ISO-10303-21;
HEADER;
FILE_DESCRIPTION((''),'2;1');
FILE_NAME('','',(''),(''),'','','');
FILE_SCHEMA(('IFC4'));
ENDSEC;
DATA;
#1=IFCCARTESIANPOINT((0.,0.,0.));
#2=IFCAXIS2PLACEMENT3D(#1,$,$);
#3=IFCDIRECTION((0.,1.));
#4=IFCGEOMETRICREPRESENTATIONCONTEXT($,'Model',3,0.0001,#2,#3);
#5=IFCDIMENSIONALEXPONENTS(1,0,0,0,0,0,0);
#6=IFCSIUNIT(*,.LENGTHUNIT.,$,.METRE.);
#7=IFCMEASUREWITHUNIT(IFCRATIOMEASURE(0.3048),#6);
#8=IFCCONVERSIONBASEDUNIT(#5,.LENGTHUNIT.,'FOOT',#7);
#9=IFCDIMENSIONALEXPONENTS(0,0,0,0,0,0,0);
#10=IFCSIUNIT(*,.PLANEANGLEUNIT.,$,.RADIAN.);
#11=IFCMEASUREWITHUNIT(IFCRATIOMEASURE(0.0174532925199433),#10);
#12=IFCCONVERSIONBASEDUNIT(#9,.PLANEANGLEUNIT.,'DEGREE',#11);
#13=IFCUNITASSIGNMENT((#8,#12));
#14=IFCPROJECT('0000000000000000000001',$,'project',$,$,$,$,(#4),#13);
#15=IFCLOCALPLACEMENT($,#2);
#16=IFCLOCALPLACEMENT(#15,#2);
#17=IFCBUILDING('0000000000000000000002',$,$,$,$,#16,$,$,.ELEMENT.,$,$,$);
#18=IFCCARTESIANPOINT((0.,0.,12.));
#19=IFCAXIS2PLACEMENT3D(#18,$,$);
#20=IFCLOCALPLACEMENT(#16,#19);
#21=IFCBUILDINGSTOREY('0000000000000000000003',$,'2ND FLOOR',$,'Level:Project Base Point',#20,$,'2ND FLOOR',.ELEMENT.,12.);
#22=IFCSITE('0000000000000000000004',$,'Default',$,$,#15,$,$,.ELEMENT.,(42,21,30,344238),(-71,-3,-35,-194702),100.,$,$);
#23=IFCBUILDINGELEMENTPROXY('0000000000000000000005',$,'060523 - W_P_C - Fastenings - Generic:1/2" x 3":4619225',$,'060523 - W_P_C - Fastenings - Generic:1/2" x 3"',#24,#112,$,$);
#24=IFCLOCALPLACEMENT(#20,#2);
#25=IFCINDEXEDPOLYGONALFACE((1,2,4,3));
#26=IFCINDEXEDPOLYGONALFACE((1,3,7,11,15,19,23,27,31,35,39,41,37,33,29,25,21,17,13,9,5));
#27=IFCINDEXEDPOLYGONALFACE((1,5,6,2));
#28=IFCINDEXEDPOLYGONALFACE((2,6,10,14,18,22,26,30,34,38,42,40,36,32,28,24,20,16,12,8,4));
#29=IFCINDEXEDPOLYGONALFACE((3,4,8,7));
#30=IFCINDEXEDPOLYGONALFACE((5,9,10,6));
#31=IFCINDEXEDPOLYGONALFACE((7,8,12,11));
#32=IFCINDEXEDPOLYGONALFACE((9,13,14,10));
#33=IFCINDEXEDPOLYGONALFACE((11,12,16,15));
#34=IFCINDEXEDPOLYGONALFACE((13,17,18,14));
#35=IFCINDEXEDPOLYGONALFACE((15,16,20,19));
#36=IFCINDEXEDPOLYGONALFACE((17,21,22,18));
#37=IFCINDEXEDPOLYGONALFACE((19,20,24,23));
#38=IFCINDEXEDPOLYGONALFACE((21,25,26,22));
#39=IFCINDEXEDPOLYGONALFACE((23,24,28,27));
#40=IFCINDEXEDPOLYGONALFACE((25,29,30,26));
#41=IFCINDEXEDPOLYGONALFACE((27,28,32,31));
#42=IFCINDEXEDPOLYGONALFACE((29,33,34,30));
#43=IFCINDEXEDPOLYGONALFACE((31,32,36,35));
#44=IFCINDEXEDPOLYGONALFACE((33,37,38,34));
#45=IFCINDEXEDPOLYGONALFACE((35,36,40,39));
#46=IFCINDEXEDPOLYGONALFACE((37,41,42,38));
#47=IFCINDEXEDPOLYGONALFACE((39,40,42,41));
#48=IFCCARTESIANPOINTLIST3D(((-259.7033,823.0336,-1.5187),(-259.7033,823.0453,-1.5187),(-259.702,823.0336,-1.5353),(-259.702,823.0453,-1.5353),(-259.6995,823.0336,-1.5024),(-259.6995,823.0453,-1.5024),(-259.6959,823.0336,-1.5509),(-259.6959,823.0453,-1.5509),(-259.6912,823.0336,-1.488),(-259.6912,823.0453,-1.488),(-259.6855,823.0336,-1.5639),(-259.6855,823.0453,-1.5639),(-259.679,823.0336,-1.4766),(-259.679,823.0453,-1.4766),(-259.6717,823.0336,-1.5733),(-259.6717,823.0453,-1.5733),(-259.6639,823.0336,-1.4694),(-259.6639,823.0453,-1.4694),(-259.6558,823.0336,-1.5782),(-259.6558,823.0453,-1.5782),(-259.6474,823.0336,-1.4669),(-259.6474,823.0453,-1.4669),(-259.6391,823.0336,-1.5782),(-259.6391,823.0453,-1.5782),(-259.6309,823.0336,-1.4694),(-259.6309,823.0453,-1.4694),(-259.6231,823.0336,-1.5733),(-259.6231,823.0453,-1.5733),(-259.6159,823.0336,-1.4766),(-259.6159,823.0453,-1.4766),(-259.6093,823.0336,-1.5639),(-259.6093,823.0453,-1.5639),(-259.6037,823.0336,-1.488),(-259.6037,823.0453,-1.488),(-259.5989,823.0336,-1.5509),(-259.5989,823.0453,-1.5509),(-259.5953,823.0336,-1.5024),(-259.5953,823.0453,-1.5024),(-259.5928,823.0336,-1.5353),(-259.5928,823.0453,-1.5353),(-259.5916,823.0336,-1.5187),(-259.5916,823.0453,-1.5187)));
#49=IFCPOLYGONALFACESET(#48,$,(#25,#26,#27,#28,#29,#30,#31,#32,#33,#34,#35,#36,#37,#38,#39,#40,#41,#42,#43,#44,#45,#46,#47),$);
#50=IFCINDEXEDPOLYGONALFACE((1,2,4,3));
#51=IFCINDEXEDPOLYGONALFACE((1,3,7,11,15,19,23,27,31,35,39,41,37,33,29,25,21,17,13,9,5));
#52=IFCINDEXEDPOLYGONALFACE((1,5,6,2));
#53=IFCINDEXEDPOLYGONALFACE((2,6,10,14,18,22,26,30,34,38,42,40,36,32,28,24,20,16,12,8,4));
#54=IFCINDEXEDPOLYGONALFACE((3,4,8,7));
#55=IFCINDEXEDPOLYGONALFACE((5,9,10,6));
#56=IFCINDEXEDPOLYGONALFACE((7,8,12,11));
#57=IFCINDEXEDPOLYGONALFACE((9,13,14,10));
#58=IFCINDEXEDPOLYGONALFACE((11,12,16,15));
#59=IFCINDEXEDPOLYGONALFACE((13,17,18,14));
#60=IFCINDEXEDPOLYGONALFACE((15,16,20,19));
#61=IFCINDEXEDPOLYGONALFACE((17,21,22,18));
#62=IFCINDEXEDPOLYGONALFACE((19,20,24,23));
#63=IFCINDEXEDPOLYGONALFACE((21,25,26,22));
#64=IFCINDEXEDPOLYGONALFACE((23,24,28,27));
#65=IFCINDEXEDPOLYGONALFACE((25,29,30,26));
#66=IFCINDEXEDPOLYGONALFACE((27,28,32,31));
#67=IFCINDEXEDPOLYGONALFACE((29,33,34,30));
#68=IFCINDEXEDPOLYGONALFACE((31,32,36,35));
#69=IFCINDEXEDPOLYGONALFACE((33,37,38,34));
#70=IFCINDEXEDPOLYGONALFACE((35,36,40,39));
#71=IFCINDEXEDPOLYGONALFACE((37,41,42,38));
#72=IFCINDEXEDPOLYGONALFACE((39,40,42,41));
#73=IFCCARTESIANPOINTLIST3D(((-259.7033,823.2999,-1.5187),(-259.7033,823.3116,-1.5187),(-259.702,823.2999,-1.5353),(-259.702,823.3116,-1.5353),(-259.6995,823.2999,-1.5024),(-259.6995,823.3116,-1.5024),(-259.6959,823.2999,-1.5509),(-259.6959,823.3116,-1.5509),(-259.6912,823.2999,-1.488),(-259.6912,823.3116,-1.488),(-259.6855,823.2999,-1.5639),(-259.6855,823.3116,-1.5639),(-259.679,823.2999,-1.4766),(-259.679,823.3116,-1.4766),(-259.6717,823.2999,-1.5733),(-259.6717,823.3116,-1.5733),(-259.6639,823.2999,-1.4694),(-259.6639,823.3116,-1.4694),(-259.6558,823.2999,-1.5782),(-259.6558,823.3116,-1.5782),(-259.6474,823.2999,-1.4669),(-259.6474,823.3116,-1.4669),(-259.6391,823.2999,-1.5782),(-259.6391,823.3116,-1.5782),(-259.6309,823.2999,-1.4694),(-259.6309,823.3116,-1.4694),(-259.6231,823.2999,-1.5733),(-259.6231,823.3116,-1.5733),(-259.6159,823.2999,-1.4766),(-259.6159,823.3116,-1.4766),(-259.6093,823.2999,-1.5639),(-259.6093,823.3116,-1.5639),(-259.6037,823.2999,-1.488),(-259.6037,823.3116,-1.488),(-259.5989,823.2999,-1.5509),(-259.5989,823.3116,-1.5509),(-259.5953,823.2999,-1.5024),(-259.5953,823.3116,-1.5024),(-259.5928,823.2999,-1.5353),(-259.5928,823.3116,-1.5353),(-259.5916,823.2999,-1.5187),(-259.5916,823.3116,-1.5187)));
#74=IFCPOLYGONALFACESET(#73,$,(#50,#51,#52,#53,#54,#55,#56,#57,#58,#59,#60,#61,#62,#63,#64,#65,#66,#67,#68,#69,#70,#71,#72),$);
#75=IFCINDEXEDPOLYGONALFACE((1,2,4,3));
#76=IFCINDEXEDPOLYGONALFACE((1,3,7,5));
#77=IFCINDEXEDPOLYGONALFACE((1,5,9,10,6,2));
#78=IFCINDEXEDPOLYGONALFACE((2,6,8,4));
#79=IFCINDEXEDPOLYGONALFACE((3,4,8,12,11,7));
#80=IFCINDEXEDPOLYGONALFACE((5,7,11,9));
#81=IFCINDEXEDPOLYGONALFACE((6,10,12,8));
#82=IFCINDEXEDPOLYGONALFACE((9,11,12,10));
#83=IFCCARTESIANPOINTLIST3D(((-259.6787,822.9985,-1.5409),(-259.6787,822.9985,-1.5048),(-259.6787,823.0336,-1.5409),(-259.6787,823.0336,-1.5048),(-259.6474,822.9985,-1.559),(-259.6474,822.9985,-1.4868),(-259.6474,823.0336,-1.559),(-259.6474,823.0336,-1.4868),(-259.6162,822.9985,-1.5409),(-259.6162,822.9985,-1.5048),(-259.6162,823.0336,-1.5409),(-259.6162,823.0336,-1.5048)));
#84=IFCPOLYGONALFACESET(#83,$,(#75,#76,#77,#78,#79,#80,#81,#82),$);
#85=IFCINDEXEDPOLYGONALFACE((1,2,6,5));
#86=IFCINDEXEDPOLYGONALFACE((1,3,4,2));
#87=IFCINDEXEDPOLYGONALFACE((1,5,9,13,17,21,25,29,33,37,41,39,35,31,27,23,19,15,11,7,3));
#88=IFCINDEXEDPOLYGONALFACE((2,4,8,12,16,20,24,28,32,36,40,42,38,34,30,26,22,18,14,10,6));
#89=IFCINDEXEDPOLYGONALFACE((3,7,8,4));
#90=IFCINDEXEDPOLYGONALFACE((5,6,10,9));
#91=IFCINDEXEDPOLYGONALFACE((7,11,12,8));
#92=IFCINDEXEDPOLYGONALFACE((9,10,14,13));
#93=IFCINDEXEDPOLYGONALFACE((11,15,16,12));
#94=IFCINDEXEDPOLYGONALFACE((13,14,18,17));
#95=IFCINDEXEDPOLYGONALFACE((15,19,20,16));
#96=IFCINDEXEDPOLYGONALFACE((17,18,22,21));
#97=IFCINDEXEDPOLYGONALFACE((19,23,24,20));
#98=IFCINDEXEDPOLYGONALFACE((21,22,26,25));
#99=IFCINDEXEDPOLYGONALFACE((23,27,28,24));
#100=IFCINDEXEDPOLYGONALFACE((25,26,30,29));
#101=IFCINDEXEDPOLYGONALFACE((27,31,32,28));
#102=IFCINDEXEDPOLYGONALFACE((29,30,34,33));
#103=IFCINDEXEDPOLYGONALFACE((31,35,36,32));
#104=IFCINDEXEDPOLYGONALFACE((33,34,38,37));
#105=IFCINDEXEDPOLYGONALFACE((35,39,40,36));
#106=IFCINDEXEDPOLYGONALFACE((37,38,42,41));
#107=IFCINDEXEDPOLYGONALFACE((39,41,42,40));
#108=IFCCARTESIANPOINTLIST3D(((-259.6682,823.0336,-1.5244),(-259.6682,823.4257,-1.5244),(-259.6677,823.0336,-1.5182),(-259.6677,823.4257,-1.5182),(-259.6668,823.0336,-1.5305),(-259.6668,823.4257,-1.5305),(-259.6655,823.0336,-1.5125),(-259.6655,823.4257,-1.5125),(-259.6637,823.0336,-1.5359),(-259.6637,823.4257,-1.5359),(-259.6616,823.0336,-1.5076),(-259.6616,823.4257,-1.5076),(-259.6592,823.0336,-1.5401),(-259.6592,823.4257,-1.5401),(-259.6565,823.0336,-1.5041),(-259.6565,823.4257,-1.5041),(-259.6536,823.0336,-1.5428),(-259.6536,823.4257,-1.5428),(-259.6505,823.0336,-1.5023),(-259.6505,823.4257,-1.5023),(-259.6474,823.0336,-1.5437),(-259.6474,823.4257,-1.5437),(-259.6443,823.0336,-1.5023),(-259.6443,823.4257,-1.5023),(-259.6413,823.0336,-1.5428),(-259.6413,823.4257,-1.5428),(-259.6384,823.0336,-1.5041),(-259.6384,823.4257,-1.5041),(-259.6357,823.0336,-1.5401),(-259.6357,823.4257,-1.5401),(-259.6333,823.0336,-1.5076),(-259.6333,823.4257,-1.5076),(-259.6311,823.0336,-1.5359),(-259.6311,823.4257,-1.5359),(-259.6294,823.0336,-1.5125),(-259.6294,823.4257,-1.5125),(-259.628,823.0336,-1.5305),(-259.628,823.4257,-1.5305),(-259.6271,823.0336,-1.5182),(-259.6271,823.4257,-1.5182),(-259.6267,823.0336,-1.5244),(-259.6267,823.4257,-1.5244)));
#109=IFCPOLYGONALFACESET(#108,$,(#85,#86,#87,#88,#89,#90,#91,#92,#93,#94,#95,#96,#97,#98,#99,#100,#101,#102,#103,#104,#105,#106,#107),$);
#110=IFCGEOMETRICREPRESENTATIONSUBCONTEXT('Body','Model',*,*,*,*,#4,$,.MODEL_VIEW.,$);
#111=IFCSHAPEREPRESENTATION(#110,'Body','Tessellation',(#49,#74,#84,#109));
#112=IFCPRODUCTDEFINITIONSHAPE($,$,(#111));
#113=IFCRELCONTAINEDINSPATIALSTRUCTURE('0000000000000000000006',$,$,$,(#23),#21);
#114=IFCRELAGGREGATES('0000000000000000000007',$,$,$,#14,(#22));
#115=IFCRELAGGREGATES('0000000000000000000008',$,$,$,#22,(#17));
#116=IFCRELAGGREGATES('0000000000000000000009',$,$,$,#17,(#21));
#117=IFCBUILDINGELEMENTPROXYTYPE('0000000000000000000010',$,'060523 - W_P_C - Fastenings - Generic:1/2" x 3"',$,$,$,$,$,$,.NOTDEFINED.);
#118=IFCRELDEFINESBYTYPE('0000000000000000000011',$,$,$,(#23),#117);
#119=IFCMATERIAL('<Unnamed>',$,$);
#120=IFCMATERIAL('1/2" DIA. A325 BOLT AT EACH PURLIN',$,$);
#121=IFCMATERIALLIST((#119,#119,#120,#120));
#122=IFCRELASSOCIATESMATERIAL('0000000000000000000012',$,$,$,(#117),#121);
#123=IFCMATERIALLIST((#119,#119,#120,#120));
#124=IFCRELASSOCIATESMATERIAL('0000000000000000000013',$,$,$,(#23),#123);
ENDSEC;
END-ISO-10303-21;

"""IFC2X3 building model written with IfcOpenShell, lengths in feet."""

from ifc_helpers import new_model, entity, si_unit, converted_unit, direction, frame, frame_2d, origin, place, context, subcontext, project, spatial, polyline, circle, outline, extrude, source, transform, mapped, material, material_list, type_object, type_shapes, element, save


model = new_model("IFC2X3")

# Units and contexts
model_context = context("Model", 3, precision=0.0001, world=origin(), true_north=direction((0.0, 1.0)))
body_context = subcontext(model_context, "Body", "Model", "MODEL_VIEW")
ifc_project = project(units=[converted_unit("LENGTHUNIT", "FOOT", entity("IfcRatioMeasure", 0.3048), si_unit("LENGTHUNIT", "METRE"), dimensions=[1, 0, 0, 0, 0, 0, 0]), converted_unit("PLANEANGLEUNIT", "DEGREE", entity("IfcRatioMeasure", 0.0174532925199433), si_unit("PLANEANGLEUNIT", "RADIAN"), dimensions=[0, 0, 0, 0, 0, 0, 0])], contexts=[model_context])

# Site, building, storey
site_placement = place(None, origin())
site = spatial("IfcSite", under=ifc_project, at=site_placement, Name="Default", CompositionType="ELEMENT", RefLatitude=(42, 21, 30, 344238), RefLongitude=(-71, -3, -35, -194702), RefElevation=100.0)
building_placement = place(site_placement, origin())
building = spatial("IfcBuilding", under=site, at=building_placement, CompositionType="ELEMENT")
storey_placement = place(building_placement, frame((0.0, 0.0, 12.0)))
storey = spatial("IfcBuildingStorey", under=building, at=storey_placement, Name="2ND FLOOR", ObjectType="Level:Project Base Point", LongName="2ND FLOOR", CompositionType="ELEMENT", Elevation=12.0)

# Building element proxy
ifc_material_1 = material(Name="<Unnamed>")
ifc_material_2 = material(Name="1/2\" DIA. A325 BOLT AT EACH PURLIN")
ifc_material_list_1 = material_list([ifc_material_1, ifc_material_1, ifc_material_2, ifc_material_2])
ifc_material_list_2 = material_list([ifc_material_1, ifc_material_1, ifc_material_2, ifc_material_2])
building_element_proxy_type_1 = type_object("IfcBuildingElementProxyType", Name="060523 - W_P_C - Fastenings - Generic:1/2\" x 3\"", PredefinedType="NOTDEFINED", material=ifc_material_list_2)
shared_shape_1 = source(origin(), body_context, "Body", "SweptSolid", [
    extrude(circle(Radius=0.056, at=frame_2d((0.0, 0.0), x_axis=(1.0, 0.0))), frame((0.0, 0.0, 0.0), z_axis=(0.0, 0.0, 1.0), x_axis=(0.0, -1.0, 0.0)), (0.0, 0.0, 1.0), 0.0117),
    extrude(circle(Radius=0.056, at=frame_2d((0.0, 0.0), x_axis=(1.0, 0.0))), frame((0.0, 0.0, -0.2662), z_axis=(0.0, 0.0, 1.0), x_axis=(0.0, -1.0, 0.0)), (0.0, 0.0, 1.0), 0.0117),
    extrude(outline(polyline([(-0.018, -0.0313), (0.018, -0.0313), (0.0361, 0.0), (0.018, 0.0313), (-0.018, 0.0313), (-0.0361, 0.0), (-0.018, -0.0313)])), frame((0.0, 0.0, 0.0117), z_axis=(0.0, 0.0, 1.0), x_axis=(0.0, -1.0, 0.0)), (0.0, 0.0, 1.0), 0.0352),
    extrude(circle(Radius=0.0208, at=frame_2d((0.0, 0.0), x_axis=(1.0, 0.0))), frame((0.0, 0.0, -0.3804), z_axis=(0.0, 0.0, 1.0), x_axis=(0.0, 1.0, 0.0)), (0.0, 0.0, 1.0), 0.3921),
])
type_shapes(building_element_proxy_type_1, [shared_shape_1])
proxy_1_placement = place(storey_placement, frame((-259.6474, 823.0453, -1.5229), z_axis=(0.0, -1.0, 0.0), x_axis=(-1.0, 0.0, 0.0)))
element("IfcBuildingElementProxy", 1, at=proxy_1_placement, inside=storey, type_object=building_element_proxy_type_1, material=ifc_material_list_1, Name="060523 - W_P_C - Fastenings - Generic:1/2\" x 3\":4619225", ObjectType="060523 - W_P_C - Fastenings - Generic:1/2\" x 3\"", context=body_context, shape_type="MappedRepresentation", body=[
    mapped(shared_shape_1, transform((0.0, 0.0, 0.0), scale=1.0)),
])

save(model, "model.ifc")
